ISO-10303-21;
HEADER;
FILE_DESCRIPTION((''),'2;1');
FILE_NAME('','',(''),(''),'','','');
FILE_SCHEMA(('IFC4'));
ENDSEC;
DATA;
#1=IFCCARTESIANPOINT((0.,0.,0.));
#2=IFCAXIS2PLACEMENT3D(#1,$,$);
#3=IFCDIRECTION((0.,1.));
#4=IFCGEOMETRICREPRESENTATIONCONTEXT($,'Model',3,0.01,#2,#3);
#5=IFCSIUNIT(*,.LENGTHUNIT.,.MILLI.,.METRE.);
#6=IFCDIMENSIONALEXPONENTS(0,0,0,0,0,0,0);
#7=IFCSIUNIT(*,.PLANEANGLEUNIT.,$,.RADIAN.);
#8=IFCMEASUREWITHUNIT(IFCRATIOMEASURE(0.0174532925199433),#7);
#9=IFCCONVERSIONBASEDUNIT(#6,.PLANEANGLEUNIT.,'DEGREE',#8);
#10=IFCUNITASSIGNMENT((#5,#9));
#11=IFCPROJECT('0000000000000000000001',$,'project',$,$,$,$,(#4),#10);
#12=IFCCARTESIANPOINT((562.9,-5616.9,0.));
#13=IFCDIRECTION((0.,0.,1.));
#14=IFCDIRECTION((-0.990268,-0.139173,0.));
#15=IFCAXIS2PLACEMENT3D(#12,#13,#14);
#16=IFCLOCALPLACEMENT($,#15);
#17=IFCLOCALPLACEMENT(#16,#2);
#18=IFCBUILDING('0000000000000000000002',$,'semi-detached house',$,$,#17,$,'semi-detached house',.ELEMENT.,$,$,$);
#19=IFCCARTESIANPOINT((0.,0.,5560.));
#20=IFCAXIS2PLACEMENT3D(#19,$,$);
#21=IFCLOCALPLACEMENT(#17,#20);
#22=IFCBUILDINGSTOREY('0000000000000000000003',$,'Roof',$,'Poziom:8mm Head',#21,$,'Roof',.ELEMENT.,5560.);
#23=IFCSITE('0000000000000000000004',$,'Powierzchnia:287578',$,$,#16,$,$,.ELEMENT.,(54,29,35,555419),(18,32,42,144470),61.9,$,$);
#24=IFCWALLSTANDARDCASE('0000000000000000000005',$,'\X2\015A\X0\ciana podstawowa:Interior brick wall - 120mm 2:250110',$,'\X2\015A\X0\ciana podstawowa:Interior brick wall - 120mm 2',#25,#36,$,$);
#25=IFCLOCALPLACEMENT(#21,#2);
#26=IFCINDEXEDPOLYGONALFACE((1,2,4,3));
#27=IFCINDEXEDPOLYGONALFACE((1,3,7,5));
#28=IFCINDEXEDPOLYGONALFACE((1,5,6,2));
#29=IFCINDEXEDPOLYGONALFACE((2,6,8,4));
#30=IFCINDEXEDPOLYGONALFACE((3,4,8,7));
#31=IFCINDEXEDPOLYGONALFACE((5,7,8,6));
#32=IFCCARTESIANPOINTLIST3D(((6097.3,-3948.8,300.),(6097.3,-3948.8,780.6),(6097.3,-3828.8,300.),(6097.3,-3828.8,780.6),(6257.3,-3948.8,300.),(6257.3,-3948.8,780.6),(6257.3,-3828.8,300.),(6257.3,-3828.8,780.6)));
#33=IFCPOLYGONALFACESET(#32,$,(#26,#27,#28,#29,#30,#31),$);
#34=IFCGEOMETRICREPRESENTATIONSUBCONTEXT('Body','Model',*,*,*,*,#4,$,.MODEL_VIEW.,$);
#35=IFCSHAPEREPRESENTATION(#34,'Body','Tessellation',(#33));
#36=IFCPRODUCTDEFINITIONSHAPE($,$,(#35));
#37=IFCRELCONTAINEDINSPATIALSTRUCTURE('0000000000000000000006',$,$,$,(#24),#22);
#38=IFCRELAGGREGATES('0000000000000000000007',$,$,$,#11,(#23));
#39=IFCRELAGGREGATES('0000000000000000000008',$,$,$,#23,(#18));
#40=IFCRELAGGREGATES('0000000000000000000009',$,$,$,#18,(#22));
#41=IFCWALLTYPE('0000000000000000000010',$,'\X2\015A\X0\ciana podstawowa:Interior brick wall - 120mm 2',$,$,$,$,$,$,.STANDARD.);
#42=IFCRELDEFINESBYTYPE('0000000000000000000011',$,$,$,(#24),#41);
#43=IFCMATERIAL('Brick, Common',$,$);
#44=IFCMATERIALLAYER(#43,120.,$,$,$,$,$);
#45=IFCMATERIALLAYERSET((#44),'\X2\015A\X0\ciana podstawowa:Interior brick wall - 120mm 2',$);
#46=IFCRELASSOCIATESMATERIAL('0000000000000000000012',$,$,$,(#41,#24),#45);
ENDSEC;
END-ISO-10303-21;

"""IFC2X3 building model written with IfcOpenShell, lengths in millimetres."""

from ifc_helpers import new_model, entity, si_unit, converted_unit, direction, frame, frame_2d, origin, place, context, subcontext, project, spatial, rectangle, extrude, material, layer, layer_set, layer_usage, type_object, element, save


model = new_model("IFC2X3")

# Units and contexts
model_context = context("Model", 3, precision=0.01, world=origin(), true_north=direction((0.0, 1.0)))
body_context = subcontext(model_context, "Body", "Model", "MODEL_VIEW")
ifc_project = project(units=[si_unit("LENGTHUNIT", "METRE", prefix="MILLI"), converted_unit("PLANEANGLEUNIT", "DEGREE", entity("IfcRatioMeasure", 0.0174532925199433), si_unit("PLANEANGLEUNIT", "RADIAN"), dimensions=[0, 0, 0, 0, 0, 0, 0])], contexts=[model_context])

# Site, building, storey
site_placement = place(None, frame((562.9, -5616.9, 0.0), z_axis=(0.0, 0.0, 1.0), x_axis=(-0.990268, -0.139173, 0.0)))
site = spatial("IfcSite", under=ifc_project, at=site_placement, Name="Powierzchnia:287578", CompositionType="ELEMENT", RefLatitude=(54, 29, 35, 555419), RefLongitude=(18, 32, 42, 144470), RefElevation=61.9)
building_placement = place(site_placement, origin())
building = spatial("IfcBuilding", under=site, at=building_placement, Name="semi-detached house", LongName="semi-detached house", CompositionType="ELEMENT")
storey_placement = place(building_placement, frame((0.0, 0.0, 5560.0)))
storey = spatial("IfcBuildingStorey", under=building, at=storey_placement, Name="Roof", ObjectType="Poziom:8mm Head", LongName="Roof", CompositionType="ELEMENT", Elevation=5560.0)

# Shared definitions
ifc_material = material(Name="Brick, Common")
ifc_layer = layer(ifc_material, 120.0)
ifc_layer_set = layer_set([ifc_layer], Name="Ściana podstawowa:Interior brick wall - 120mm 2")
wall_type = type_object("IfcWallType", Name="Ściana podstawowa:Interior brick wall - 120mm 2", PredefinedType="STANDARD", material=ifc_layer_set)

# Wall
ifc_layer_usage_1 = layer_usage(ifc_layer_set, "AXIS2", "NEGATIVE", 60.0)
wall_1_placement = place(storey_placement, frame((6097.3, -3888.8, 300.0)))
element("IfcWallStandardCase", 1, at=wall_1_placement, inside=storey, type_object=wall_type, material=ifc_layer_usage_1, Name="Ściana podstawowa:Interior brick wall - 120mm 2:250110", ObjectType="Ściana podstawowa:Interior brick wall - 120mm 2", context=body_context, shape_type="SweptSolid", body=[
    extrude(rectangle(XDim=160.0, YDim=120.0, at=frame_2d((80.0, 0.0), x_axis=(-1.0, 0.0))), origin(), (0.0, 0.0, 1.0), 480.6),
])

save(model, "model.ifc")
